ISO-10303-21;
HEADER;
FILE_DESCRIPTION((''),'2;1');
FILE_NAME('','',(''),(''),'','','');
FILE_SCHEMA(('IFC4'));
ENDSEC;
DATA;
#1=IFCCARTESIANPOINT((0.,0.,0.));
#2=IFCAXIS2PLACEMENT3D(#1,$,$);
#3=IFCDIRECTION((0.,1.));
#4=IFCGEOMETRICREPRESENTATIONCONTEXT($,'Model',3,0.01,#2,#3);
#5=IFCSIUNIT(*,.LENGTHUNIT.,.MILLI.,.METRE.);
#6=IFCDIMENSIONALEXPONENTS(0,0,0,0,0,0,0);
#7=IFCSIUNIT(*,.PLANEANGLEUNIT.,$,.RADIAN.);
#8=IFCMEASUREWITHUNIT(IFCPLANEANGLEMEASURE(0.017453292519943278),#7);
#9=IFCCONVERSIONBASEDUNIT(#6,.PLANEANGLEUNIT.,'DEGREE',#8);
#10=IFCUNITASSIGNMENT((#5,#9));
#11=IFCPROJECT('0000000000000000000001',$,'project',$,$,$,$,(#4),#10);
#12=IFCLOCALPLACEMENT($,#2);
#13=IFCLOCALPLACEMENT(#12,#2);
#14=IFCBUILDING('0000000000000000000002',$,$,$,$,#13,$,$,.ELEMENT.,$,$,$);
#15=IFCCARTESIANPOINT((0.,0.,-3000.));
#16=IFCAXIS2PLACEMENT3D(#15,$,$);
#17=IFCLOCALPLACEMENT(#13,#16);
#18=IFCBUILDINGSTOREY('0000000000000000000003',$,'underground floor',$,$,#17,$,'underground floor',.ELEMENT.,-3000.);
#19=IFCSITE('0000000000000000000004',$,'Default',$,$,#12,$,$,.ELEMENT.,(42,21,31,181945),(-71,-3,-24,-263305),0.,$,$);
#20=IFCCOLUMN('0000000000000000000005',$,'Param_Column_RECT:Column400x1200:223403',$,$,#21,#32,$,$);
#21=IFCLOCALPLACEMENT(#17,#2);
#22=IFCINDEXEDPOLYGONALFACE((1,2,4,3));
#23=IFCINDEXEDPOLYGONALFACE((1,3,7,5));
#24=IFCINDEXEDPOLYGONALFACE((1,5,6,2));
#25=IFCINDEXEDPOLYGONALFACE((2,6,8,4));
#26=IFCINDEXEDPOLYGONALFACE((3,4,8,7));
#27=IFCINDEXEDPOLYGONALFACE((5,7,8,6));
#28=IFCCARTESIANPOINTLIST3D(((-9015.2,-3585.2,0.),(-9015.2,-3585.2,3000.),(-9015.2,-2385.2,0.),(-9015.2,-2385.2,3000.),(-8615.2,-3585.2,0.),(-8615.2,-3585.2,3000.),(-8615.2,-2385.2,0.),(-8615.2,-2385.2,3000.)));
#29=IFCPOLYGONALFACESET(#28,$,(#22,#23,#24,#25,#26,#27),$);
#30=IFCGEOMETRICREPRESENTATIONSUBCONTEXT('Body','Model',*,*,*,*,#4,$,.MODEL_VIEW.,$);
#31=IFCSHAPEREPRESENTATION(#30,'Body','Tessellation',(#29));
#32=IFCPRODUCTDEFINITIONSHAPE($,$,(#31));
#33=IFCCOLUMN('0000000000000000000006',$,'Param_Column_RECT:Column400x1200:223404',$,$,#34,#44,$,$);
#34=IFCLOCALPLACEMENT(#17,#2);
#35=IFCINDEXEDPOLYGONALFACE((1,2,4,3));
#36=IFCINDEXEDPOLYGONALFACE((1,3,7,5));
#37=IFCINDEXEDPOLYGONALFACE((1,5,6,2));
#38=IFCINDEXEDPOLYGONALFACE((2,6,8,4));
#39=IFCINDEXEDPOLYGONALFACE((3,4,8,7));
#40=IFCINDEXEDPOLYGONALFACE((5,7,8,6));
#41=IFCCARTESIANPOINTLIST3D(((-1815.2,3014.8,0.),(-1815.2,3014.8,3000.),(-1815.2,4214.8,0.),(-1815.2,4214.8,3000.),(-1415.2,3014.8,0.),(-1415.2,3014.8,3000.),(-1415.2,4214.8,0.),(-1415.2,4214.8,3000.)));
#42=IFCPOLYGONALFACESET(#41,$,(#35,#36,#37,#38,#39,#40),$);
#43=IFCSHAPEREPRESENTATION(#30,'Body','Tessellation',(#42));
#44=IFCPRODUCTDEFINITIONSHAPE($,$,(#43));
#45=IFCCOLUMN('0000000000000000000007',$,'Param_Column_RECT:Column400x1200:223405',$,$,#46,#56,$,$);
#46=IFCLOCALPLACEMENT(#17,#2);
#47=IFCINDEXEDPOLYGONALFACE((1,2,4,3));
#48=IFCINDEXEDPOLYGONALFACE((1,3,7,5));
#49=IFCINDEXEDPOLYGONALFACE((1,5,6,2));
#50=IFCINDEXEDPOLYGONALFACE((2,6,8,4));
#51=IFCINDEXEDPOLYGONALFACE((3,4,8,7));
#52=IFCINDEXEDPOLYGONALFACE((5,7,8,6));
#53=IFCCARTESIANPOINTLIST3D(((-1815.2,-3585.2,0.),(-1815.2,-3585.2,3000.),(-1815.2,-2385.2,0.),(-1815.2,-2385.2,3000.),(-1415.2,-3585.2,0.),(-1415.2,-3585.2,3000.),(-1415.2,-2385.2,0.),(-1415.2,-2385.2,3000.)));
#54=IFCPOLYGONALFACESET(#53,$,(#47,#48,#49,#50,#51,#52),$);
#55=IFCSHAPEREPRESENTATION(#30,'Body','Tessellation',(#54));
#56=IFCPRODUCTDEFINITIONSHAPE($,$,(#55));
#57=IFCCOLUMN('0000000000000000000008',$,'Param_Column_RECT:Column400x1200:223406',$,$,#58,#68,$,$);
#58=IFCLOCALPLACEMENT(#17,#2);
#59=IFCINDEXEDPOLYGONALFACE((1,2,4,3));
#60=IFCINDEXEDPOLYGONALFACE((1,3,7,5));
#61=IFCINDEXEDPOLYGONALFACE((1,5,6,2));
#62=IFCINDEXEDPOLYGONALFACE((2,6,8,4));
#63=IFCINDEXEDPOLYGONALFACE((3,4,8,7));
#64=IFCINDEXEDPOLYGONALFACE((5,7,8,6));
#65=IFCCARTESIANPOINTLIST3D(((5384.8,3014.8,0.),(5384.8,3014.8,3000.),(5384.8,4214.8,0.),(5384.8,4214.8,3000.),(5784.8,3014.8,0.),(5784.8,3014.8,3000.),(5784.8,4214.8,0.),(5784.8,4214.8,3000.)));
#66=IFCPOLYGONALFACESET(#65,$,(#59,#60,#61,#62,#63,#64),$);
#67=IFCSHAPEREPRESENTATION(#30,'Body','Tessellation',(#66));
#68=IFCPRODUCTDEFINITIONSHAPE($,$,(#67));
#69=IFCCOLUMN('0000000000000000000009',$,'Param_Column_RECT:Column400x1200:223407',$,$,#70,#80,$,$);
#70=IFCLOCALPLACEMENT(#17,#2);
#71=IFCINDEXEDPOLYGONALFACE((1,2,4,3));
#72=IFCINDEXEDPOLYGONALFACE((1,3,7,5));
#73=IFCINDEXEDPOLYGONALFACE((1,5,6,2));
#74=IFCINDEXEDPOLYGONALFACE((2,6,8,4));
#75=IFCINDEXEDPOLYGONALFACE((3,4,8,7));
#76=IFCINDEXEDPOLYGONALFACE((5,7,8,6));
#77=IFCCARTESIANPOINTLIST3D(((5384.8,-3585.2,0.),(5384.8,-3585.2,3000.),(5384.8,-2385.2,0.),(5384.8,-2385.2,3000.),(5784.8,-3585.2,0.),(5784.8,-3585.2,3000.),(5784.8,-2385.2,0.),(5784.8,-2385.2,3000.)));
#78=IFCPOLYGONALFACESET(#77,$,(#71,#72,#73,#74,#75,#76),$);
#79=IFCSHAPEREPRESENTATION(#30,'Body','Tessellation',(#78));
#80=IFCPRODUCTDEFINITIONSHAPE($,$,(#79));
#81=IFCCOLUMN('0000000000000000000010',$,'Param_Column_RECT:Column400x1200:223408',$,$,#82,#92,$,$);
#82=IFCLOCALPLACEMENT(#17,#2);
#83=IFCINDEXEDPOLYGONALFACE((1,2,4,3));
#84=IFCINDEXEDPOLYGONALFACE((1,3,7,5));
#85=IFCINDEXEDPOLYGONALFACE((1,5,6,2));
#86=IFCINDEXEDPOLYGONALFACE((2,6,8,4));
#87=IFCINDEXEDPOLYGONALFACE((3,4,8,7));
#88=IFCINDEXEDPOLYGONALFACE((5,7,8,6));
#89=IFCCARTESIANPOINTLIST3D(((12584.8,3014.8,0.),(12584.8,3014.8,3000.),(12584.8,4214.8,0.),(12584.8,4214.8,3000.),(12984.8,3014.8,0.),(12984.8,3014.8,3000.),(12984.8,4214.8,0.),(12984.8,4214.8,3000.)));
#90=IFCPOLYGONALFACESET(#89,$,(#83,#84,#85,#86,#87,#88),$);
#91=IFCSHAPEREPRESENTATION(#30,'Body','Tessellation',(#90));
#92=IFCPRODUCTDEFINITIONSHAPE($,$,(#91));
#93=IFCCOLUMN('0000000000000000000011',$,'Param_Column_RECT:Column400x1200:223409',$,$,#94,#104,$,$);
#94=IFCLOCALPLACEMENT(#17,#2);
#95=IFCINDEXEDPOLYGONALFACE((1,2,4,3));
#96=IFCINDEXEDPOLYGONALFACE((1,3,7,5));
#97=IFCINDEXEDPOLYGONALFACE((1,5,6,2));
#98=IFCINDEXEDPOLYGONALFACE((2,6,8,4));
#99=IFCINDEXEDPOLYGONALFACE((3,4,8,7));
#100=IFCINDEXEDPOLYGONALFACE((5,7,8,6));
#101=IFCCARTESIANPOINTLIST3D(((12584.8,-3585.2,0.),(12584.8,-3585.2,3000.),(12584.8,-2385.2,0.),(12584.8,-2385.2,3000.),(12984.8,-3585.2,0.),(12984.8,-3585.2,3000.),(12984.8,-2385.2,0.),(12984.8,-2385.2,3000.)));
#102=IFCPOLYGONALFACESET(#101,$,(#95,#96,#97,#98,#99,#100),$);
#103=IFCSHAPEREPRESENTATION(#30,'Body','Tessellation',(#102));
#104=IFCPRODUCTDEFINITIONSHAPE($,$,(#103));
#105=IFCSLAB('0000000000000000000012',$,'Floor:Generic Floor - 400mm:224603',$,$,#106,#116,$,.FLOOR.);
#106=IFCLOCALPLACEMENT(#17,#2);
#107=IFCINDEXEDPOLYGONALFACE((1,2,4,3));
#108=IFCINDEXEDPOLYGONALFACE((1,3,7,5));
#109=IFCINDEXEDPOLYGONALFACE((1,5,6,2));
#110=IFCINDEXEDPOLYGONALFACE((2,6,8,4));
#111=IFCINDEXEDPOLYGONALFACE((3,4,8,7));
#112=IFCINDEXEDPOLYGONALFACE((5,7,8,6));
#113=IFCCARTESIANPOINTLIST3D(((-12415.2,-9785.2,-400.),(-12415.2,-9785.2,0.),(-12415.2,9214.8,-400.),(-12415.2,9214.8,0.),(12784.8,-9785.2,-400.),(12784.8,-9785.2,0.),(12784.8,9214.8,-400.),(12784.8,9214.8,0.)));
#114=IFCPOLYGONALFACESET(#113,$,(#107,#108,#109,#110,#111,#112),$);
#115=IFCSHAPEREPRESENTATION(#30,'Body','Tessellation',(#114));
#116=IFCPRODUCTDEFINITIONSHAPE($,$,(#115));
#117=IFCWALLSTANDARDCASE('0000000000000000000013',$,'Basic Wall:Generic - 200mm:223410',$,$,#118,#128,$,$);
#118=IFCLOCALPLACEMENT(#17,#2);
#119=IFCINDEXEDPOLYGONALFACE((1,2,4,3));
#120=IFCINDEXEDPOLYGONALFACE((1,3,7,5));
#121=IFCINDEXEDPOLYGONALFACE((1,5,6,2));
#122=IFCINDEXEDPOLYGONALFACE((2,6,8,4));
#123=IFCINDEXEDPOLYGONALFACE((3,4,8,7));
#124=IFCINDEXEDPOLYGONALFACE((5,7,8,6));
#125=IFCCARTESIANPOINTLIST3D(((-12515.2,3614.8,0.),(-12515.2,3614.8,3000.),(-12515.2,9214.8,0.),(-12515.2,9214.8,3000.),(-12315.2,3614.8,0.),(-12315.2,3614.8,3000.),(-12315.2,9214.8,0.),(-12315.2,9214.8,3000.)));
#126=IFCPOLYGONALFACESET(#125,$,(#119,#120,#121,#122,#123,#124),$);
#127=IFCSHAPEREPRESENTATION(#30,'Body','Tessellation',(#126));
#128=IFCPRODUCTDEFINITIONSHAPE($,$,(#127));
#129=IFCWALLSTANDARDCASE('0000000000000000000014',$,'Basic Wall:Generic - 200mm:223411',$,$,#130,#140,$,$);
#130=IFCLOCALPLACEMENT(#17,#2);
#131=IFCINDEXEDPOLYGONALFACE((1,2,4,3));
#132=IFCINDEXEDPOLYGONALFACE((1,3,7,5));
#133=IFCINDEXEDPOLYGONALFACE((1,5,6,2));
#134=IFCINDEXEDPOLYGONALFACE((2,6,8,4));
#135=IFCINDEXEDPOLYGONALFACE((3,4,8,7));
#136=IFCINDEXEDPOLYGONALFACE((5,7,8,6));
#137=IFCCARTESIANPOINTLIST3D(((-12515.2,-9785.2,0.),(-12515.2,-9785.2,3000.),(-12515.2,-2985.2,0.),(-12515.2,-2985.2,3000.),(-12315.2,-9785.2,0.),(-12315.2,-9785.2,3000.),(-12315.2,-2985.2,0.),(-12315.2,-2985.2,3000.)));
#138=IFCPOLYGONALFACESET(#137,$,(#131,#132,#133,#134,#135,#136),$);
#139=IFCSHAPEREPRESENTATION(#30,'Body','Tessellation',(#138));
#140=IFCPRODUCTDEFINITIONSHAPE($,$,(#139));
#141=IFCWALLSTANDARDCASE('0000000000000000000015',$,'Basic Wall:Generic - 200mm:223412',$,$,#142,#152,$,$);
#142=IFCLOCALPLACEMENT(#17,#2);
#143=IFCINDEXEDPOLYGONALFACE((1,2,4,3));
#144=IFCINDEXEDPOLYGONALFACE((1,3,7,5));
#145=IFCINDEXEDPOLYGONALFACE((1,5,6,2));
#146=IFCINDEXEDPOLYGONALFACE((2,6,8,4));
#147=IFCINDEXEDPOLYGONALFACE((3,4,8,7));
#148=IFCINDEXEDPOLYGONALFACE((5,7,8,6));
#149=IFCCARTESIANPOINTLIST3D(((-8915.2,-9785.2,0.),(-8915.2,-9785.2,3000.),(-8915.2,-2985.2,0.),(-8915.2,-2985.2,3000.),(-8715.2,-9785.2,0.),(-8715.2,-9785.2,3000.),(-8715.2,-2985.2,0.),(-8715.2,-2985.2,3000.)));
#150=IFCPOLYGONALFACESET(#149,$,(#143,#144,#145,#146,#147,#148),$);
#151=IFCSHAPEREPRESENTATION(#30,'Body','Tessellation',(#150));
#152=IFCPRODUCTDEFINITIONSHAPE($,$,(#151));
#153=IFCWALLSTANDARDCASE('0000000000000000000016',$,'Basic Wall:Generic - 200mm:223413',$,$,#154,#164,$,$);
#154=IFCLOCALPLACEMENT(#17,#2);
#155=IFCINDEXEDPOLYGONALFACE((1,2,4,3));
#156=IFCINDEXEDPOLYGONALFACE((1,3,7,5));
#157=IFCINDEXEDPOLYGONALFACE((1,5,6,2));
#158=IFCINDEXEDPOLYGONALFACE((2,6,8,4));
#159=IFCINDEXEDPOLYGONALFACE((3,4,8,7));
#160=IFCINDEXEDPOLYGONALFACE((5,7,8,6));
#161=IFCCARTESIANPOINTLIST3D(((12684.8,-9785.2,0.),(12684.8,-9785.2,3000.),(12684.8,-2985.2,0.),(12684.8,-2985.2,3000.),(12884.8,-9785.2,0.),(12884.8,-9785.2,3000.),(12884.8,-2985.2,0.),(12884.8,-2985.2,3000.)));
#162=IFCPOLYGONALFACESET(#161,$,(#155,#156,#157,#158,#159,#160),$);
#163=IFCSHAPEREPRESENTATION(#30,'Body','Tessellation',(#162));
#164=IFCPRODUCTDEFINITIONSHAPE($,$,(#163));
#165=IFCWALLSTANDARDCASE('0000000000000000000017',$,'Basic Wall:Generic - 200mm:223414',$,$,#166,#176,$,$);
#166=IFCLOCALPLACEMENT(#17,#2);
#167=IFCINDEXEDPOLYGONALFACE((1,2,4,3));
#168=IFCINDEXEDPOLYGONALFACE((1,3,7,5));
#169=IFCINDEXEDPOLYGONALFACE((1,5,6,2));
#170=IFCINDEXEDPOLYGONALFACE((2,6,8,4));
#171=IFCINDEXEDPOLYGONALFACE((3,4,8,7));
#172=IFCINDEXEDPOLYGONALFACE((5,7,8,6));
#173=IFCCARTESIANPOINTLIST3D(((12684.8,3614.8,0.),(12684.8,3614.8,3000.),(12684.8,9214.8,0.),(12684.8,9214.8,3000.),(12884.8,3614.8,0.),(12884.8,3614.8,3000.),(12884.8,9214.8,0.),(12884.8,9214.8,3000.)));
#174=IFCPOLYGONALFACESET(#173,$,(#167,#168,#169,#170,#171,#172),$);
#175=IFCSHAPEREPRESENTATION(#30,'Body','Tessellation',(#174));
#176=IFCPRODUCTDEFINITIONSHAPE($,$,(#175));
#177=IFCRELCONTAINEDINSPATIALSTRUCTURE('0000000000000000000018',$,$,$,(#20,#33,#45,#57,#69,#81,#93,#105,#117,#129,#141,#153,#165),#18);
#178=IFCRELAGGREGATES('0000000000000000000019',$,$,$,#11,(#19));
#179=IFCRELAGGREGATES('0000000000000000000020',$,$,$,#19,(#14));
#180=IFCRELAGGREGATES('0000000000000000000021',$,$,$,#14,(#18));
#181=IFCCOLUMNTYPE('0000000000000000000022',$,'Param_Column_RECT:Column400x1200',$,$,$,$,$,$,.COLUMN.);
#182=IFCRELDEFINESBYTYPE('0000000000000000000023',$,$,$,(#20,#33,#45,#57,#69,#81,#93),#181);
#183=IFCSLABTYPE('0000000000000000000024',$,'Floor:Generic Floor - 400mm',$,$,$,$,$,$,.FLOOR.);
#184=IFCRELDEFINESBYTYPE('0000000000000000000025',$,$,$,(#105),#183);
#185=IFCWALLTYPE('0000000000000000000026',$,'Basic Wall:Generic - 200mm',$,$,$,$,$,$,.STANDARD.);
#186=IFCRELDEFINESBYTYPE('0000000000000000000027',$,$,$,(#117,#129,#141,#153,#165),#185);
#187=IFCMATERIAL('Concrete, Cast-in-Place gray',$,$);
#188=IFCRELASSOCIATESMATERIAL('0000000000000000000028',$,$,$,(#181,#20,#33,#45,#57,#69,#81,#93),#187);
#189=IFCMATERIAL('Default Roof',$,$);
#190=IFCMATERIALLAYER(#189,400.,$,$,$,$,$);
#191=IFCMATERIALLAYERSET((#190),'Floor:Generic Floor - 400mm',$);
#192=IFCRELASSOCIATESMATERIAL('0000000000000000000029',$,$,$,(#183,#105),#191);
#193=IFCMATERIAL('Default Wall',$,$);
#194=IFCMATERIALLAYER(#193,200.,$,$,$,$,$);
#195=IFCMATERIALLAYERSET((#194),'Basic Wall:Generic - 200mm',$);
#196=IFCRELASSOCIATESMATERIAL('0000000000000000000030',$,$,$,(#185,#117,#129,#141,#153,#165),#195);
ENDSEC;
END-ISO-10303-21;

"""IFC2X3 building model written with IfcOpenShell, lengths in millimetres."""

from ifc_helpers import new_model, entity, si_unit, converted_unit, direction, frame, frame_2d, origin, origin_2d_with_axis, place, context, subcontext, project, spatial, rectangle, extrude, source, transform, mapped, material, layer, layer_set, layer_usage, type_object, type_shapes, element, save


model = new_model("IFC2X3")

# Units and contexts
model_context = context("Model", 3, precision=0.01, world=origin(), true_north=direction((0.0, 1.0)))
body_context = subcontext(model_context, "Body", "Model", "MODEL_VIEW")
ifc_project = project(units=[si_unit("LENGTHUNIT", "METRE", prefix="MILLI"), converted_unit("PLANEANGLEUNIT", "DEGREE", entity("IfcPlaneAngleMeasure", 0.017453292519943278), si_unit("PLANEANGLEUNIT", "RADIAN"), dimensions=[0, 0, 0, 0, 0, 0, 0])], contexts=[model_context])

# Site, building, storey
site_placement = place(None, origin())
site = spatial("IfcSite", under=ifc_project, at=site_placement, Name="Default", CompositionType="ELEMENT", RefLatitude=(42, 21, 31, 181945), RefLongitude=(-71, -3, -24, -263305), RefElevation=0.0)
building_placement = place(site_placement, origin())
building = spatial("IfcBuilding", under=site, at=building_placement, CompositionType="ELEMENT")
storey_placement = place(building_placement, frame((0.0, 0.0, -3000.0)))
storey = spatial("IfcBuildingStorey", under=building, at=storey_placement, Name="underground floor", LongName="underground floor", CompositionType="ELEMENT", Elevation=-3000.0)

# Columns
ifc_material_1 = material(Name="Concrete, Cast-in-Place gray")
column_type_1 = type_object("IfcColumnType", Name="Param_Column_RECT:Column400x1200", PredefinedType="COLUMN", material=ifc_material_1)
shared_shape_1 = source(origin(), body_context, "Body", "SweptSolid", [
    extrude(rectangle(XDim=400.0, YDim=1200.0, at=origin_2d_with_axis()), frame((0.0, 0.0, -3000.0), z_axis=(0.0, 0.0, 1.0), x_axis=(-1.0, 0.0, 0.0)), (0.0, 0.0, 1.0), 3000.0),
])
type_shapes(column_type_1, [shared_shape_1])
for number, where, name in (
    (1, (-8815.2, -2985.2, 3000.0), "Param_Column_RECT:Column400x1200:223403"),
    (2, (-1615.2, 3614.8, 3000.0), "Param_Column_RECT:Column400x1200:223404"),
    (3, (-1615.2, -2985.2, 3000.0), "Param_Column_RECT:Column400x1200:223405"),
    (4, (5584.8, 3614.8, 3000.0), "Param_Column_RECT:Column400x1200:223406"),
    (5, (5584.8, -2985.2, 3000.0), "Param_Column_RECT:Column400x1200:223407"),
    (6, (12784.8, 3614.8, 3000.0), "Param_Column_RECT:Column400x1200:223408"),
    (7, (12784.8, -2985.2, 3000.0), "Param_Column_RECT:Column400x1200:223409"),
):
    element("IfcColumn", number, at=place(storey_placement, frame(where)), inside=storey, type_object=column_type_1, material=ifc_material_1, Name=name, context=body_context, shape_type="MappedRepresentation", body=[
        mapped(shared_shape_1, transform((0.0, 0.0, 0.0), scale=1.0)),
    ])

# Slab
ifc_material_2 = material(Name="Default Roof")
ifc_layer_1 = layer(ifc_material_2, 400.0)
ifc_layer_set_1 = layer_set([ifc_layer_1], Name="Floor:Generic Floor - 400mm")
ifc_layer_usage_1 = layer_usage(ifc_layer_set_1, "AXIS3", "POSITIVE", 0.0)
slab_type = type_object("IfcSlabType", Name="Floor:Generic Floor - 400mm", PredefinedType="FLOOR", material=ifc_layer_set_1)
slab_placement = place(storey_placement, origin())
element("IfcSlab", 8, at=slab_placement, inside=storey, type_object=slab_type, material=ifc_layer_usage_1, Name="Floor:Generic Floor - 400mm:224603", PredefinedType="FLOOR", context=body_context, shape_type="SweptSolid", body=[
    extrude(rectangle(XDim=19000.0, YDim=25200.0, at=frame_2d((0.0, 0.0), x_axis=(1.0, 0.0))), frame((184.8, -285.2, 0.0), z_axis=(0.0, 0.0, -1.0), x_axis=(0.0, 1.0, 0.0)), (0.0, 0.0, 1.0), 400.0),
])

# Walls
ifc_material_3 = material(Name="Default Wall")
ifc_layer_2 = layer(ifc_material_3, 200.0)
ifc_layer_set_2 = layer_set([ifc_layer_2], Name="Basic Wall:Generic - 200mm")
ifc_layer_usage_2 = layer_usage(ifc_layer_set_2, "AXIS2", "NEGATIVE", 100.0)
wall_type = type_object("IfcWallType", Name="Basic Wall:Generic - 200mm", PredefinedType="STANDARD", material=ifc_layer_set_2)
wall_1_placement = place(storey_placement, frame((-12415.2, 3614.8, 0.0), z_axis=(0.0, 0.0, 1.0), x_axis=(0.0, 1.0, 0.0)))
element("IfcWallStandardCase", 9, at=wall_1_placement, inside=storey, type_object=wall_type, material=ifc_layer_usage_2, Name="Basic Wall:Generic - 200mm:223410", context=body_context, shape_type="SweptSolid", body=[
    extrude(rectangle(XDim=5600.0, YDim=200.0, at=frame_2d((2800.0, 0.0), x_axis=(-1.0, 0.0))), origin(), (0.0, 0.0, 1.0), 3000.0),
])
ifc_layer_usage_3 = layer_usage(ifc_layer_set_2, "AXIS2", "NEGATIVE", 100.0)
wall_2_placement = place(storey_placement, frame((-12415.2, -9785.2, 0.0), z_axis=(0.0, 0.0, 1.0), x_axis=(0.0, 1.0, 0.0)))
element("IfcWallStandardCase", 10, at=wall_2_placement, inside=storey, type_object=wall_type, material=ifc_layer_usage_3, Name="Basic Wall:Generic - 200mm:223411", context=body_context, shape_type="SweptSolid", body=[
    extrude(rectangle(XDim=6800.0, YDim=200.0, at=frame_2d((3400.0, 0.0), x_axis=(-1.0, 0.0))), origin(), (0.0, 0.0, 1.0), 3000.0),
])
ifc_layer_usage_4 = layer_usage(ifc_layer_set_2, "AXIS2", "NEGATIVE", 100.0)
wall_3_placement = place(storey_placement, frame((-8815.2, -9785.2, 0.0), z_axis=(0.0, 0.0, 1.0), x_axis=(0.0, 1.0, 0.0)))
element("IfcWallStandardCase", 11, at=wall_3_placement, inside=storey, type_object=wall_type, material=ifc_layer_usage_4, Name="Basic Wall:Generic - 200mm:223412", context=body_context, shape_type="SweptSolid", body=[
    extrude(rectangle(XDim=6800.0, YDim=200.0, at=frame_2d((3400.0, 0.0), x_axis=(-1.0, 0.0))), origin(), (0.0, 0.0, 1.0), 3000.0),
])
ifc_layer_usage_5 = layer_usage(ifc_layer_set_2, "AXIS2", "NEGATIVE", 100.0)
wall_4_placement = place(storey_placement, frame((12784.8, -9785.2, 0.0), z_axis=(0.0, 0.0, 1.0), x_axis=(0.0, 1.0, 0.0)))
element("IfcWallStandardCase", 12, at=wall_4_placement, inside=storey, type_object=wall_type, material=ifc_layer_usage_5, Name="Basic Wall:Generic - 200mm:223413", context=body_context, shape_type="SweptSolid", body=[
    extrude(rectangle(XDim=6800.0, YDim=200.0, at=frame_2d((3400.0, 0.0), x_axis=(-1.0, 0.0))), origin(), (0.0, 0.0, 1.0), 3000.0),
])
ifc_layer_usage_6 = layer_usage(ifc_layer_set_2, "AXIS2", "NEGATIVE", 100.0)
wall_5_placement = place(storey_placement, frame((12784.8, 3614.8, 0.0), z_axis=(0.0, 0.0, 1.0), x_axis=(0.0, 1.0, 0.0)))
element("IfcWallStandardCase", 13, at=wall_5_placement, inside=storey, type_object=wall_type, material=ifc_layer_usage_6, Name="Basic Wall:Generic - 200mm:223414", context=body_context, shape_type="SweptSolid", body=[
    extrude(rectangle(XDim=5600.0, YDim=200.0, at=frame_2d((2800.0, 0.0), x_axis=(-1.0, 0.0))), origin(), (0.0, 0.0, 1.0), 3000.0),
])

save(model, "model.ifc")
